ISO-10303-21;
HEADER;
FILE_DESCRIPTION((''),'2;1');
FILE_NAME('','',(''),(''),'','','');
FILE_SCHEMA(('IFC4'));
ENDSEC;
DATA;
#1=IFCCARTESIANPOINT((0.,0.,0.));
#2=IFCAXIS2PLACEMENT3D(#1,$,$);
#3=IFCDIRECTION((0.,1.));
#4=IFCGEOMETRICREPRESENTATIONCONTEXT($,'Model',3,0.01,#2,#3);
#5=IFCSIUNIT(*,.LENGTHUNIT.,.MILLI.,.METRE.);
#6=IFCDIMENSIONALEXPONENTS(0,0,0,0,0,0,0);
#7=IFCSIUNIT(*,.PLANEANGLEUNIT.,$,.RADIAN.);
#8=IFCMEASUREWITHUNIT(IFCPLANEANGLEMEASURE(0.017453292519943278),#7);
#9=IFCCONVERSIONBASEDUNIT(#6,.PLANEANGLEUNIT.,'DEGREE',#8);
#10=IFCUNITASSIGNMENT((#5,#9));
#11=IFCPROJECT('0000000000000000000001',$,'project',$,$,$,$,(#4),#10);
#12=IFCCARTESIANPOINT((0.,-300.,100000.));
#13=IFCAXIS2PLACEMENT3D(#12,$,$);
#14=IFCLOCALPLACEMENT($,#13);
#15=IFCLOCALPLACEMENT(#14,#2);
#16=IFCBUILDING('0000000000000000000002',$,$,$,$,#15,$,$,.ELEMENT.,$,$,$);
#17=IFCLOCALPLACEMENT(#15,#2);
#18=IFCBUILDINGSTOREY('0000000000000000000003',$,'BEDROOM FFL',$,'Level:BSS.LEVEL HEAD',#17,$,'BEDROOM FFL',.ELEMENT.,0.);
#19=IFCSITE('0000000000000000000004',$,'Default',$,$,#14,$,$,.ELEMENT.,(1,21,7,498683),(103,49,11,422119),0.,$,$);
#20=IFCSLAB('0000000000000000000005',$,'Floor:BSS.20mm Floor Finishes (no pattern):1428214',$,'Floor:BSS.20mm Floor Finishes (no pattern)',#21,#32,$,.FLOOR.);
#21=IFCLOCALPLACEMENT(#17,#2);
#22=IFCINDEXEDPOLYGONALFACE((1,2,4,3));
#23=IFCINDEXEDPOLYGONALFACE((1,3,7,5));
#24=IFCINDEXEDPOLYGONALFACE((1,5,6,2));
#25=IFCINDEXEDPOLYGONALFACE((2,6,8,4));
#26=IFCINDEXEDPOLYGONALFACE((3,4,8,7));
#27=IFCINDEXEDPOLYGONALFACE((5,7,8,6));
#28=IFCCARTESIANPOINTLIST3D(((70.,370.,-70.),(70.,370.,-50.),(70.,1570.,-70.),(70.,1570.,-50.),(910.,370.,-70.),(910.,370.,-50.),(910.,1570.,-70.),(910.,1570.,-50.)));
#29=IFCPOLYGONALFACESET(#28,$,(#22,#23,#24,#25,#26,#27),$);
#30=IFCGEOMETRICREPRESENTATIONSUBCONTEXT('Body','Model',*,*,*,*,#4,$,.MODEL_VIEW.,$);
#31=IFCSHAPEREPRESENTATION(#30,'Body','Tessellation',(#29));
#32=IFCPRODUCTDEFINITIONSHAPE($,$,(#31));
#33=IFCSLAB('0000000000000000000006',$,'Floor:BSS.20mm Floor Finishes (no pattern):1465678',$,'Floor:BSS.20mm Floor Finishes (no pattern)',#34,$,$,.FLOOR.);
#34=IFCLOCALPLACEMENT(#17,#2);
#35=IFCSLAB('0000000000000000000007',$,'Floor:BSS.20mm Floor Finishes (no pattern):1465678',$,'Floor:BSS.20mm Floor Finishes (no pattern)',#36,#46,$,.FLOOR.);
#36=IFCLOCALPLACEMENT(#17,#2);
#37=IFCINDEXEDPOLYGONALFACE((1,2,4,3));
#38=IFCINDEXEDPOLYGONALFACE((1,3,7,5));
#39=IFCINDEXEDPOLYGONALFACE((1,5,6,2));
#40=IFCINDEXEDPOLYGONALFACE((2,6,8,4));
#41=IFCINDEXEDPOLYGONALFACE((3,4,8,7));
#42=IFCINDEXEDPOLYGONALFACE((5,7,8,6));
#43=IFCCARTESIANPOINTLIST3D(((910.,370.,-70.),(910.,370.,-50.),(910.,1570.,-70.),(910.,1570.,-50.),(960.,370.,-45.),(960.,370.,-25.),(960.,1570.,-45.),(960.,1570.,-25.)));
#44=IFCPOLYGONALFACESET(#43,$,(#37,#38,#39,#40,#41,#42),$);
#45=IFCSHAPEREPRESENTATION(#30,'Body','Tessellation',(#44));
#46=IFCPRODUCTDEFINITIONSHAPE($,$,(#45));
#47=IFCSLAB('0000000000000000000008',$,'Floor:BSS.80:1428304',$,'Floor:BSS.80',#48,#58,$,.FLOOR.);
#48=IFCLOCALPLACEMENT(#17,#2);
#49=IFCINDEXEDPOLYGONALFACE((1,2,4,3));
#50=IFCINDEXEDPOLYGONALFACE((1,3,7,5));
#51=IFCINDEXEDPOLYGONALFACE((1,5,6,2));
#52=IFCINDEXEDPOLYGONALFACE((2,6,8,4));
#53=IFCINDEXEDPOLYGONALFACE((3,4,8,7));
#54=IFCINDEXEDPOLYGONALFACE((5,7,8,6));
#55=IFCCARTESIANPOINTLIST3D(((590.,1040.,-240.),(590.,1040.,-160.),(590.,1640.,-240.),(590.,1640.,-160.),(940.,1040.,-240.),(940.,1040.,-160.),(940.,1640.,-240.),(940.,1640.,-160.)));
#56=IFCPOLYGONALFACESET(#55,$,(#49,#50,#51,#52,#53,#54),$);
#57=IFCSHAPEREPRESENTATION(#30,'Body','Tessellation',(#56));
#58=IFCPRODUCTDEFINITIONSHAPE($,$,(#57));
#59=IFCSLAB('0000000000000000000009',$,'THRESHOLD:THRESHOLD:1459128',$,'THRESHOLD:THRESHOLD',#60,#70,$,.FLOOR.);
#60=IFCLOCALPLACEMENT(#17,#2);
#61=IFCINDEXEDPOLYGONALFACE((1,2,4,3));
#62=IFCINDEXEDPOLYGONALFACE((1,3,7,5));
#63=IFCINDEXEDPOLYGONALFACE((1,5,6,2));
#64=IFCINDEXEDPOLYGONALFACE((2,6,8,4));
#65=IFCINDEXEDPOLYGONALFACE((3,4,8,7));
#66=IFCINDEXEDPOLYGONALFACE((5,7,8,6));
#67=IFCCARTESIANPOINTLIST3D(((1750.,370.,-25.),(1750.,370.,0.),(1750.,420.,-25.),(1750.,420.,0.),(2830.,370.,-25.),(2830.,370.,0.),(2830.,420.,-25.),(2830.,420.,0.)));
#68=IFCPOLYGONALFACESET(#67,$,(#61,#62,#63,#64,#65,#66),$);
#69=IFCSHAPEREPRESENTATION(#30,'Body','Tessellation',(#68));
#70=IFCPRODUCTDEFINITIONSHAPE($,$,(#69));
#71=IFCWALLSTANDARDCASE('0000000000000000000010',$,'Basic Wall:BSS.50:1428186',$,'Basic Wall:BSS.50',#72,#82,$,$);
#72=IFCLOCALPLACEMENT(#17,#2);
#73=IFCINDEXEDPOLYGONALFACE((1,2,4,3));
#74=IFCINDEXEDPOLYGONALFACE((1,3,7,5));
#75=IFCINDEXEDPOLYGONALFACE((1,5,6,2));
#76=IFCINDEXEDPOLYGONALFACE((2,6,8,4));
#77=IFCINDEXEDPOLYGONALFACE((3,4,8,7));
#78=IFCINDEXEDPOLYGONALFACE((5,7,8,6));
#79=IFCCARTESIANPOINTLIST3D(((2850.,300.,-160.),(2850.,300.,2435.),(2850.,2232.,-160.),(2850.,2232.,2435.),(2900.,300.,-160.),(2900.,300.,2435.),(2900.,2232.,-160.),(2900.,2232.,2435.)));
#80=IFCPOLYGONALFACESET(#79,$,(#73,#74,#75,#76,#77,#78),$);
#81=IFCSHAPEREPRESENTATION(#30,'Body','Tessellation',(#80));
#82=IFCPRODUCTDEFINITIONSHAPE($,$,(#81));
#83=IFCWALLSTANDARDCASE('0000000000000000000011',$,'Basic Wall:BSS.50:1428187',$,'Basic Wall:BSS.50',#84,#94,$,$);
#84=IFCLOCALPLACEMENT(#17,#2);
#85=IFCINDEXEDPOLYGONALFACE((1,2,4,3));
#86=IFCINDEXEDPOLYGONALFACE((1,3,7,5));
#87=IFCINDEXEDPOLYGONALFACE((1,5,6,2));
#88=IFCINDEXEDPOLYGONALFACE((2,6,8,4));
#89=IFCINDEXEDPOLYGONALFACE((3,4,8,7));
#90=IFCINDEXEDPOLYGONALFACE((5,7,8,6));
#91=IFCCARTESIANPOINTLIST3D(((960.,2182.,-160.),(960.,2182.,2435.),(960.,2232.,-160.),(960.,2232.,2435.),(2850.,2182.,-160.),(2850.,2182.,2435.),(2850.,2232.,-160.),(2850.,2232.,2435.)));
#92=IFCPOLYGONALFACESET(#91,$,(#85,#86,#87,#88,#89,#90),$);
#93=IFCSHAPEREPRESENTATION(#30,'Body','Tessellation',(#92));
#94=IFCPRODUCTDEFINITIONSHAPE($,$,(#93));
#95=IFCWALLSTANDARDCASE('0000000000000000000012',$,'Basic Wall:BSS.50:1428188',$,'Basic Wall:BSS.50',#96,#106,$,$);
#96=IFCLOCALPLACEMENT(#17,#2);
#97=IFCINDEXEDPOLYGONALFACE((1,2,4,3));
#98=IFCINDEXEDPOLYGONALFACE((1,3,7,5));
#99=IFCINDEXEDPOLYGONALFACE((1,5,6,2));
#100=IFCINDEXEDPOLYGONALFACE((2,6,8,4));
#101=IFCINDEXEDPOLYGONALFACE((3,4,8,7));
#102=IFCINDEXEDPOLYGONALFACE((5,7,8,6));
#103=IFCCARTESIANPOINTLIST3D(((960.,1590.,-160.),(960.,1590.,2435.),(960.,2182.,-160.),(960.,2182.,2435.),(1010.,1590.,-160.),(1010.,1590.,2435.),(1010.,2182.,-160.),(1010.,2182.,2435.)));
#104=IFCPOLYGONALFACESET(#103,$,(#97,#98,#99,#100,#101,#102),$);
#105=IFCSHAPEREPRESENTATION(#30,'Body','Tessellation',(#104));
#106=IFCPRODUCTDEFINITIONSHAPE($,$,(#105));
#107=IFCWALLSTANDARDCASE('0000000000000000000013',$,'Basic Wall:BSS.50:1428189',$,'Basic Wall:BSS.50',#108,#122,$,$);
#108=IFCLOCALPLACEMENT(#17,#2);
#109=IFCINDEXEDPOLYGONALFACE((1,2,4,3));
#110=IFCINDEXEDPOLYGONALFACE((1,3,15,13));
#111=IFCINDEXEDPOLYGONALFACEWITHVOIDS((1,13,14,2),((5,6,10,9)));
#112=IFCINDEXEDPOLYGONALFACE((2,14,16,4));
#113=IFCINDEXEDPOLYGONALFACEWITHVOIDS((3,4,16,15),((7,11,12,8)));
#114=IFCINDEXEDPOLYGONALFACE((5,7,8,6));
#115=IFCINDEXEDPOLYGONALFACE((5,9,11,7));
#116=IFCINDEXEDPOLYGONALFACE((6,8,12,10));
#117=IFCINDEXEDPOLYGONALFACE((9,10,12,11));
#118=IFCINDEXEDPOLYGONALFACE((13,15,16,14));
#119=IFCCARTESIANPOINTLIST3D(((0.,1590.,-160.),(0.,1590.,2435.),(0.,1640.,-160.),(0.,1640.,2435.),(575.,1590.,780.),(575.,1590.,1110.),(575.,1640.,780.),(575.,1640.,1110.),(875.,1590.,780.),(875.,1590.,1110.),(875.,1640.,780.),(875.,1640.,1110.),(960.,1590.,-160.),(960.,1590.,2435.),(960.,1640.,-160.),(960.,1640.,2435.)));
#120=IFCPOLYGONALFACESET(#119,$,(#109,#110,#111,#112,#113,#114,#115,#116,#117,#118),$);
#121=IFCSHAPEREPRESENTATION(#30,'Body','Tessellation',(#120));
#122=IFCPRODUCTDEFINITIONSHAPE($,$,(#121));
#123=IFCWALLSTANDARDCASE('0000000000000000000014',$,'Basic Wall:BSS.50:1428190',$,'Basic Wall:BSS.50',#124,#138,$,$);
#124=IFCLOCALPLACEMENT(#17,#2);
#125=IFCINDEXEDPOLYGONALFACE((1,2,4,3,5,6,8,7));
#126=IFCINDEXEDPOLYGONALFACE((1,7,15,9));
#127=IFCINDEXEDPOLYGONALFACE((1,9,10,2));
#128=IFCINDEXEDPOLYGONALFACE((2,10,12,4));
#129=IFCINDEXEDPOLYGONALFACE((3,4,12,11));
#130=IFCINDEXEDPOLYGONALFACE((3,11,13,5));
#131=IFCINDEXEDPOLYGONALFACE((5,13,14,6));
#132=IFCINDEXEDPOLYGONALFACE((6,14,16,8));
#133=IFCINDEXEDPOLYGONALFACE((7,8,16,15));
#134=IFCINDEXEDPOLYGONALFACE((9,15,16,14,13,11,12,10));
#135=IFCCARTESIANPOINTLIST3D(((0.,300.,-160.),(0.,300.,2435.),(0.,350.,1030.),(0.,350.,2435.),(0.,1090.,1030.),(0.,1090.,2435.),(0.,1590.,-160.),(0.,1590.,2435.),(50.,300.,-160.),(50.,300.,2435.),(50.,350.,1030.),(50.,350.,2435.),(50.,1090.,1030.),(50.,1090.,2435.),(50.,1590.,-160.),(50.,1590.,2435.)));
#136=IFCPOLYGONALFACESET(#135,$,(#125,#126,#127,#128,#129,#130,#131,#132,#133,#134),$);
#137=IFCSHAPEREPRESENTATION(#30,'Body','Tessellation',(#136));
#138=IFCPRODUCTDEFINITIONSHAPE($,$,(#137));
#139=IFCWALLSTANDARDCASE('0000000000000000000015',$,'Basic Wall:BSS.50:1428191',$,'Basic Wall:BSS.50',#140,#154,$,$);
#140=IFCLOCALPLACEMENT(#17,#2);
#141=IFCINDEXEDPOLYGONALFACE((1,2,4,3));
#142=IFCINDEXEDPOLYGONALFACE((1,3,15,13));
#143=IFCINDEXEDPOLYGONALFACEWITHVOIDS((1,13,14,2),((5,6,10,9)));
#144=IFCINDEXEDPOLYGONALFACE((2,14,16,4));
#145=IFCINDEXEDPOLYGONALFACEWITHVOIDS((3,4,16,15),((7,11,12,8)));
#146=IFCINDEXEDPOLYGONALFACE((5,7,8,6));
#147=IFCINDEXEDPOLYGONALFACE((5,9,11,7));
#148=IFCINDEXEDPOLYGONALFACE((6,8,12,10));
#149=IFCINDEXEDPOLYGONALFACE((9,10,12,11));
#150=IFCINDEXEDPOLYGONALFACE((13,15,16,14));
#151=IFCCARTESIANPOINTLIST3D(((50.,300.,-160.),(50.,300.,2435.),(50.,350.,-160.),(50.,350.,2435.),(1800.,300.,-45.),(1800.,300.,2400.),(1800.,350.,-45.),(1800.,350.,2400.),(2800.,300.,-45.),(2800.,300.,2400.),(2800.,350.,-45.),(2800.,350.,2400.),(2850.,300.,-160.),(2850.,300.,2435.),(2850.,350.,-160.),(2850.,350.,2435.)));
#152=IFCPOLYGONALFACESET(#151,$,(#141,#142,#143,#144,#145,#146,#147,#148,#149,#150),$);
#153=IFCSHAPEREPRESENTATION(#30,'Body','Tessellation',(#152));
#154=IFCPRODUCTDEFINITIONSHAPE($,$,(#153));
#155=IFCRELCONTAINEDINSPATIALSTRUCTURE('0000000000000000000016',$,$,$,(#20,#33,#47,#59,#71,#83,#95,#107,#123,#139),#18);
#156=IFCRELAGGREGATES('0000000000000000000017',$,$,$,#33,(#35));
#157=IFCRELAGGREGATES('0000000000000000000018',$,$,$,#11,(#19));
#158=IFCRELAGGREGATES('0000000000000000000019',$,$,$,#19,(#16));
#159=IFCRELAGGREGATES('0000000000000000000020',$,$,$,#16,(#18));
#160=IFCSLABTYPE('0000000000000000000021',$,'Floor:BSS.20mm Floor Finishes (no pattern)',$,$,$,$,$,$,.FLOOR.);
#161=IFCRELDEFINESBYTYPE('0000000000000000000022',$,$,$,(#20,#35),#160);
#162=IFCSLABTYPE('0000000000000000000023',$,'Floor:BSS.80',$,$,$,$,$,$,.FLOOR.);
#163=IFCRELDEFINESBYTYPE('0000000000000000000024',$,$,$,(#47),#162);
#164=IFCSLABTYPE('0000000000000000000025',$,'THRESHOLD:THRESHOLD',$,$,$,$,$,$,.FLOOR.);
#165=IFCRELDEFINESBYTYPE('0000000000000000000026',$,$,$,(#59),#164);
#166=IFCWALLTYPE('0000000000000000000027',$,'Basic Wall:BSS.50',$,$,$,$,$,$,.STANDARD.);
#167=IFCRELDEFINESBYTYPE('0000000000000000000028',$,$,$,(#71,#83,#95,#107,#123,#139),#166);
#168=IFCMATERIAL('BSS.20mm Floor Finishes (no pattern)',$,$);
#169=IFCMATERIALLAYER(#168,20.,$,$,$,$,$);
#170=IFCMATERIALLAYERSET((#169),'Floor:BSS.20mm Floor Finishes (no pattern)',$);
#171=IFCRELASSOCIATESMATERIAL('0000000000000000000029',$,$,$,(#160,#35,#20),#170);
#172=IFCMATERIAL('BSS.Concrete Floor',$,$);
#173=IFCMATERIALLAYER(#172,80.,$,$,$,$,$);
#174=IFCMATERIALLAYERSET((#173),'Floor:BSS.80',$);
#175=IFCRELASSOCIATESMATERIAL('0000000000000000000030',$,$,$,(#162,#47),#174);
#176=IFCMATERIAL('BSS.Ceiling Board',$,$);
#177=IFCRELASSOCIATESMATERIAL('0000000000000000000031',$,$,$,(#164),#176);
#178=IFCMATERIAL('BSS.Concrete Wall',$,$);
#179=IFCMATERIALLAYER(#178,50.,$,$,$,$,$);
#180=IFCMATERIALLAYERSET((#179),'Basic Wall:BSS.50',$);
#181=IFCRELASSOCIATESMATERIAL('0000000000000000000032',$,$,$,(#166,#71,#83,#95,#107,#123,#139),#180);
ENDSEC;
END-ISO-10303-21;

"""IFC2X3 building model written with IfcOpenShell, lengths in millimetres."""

from ifc_helpers import new_model, entity, si_unit, converted_unit, direction, frame, frame_2d, origin, place, context, subcontext, project, spatial, rectangle, extrude, material, layer, layer_set, layer_usage, type_object, element, aggregate, save


model = new_model("IFC2X3")

# Units and contexts
model_context = context("Model", 3, precision=0.01, world=origin(), true_north=direction((0.0, 1.0)))
body_context = subcontext(model_context, "Body", "Model", "MODEL_VIEW")
ifc_project = project(units=[si_unit("LENGTHUNIT", "METRE", prefix="MILLI"), converted_unit("PLANEANGLEUNIT", "DEGREE", entity("IfcPlaneAngleMeasure", 0.017453292519943278), si_unit("PLANEANGLEUNIT", "RADIAN"), dimensions=[0, 0, 0, 0, 0, 0, 0])], contexts=[model_context])

# Site, building, storey
site_placement = place(None, frame((0.0, -300.0, 100000.0)))
site = spatial("IfcSite", under=ifc_project, at=site_placement, Name="Default", CompositionType="ELEMENT", RefLatitude=(1, 21, 7, 498683), RefLongitude=(103, 49, 11, 422119), RefElevation=0.0)
building_placement = place(site_placement, origin())
building = spatial("IfcBuilding", under=site, at=building_placement, CompositionType="ELEMENT")
storey_placement = place(building_placement, origin())
storey = spatial("IfcBuildingStorey", under=building, at=storey_placement, Name="BEDROOM FFL", ObjectType="Level:BSS.LEVEL HEAD", LongName="BEDROOM FFL", CompositionType="ELEMENT", Elevation=0.0)

# Slabs
ifc_material_1 = material(Name="BSS.Concrete Floor")
ifc_material_2 = material(Name="BSS.20mm Floor Finishes (no pattern)")
ifc_layer_1 = layer(ifc_material_2, 20.0)
ifc_layer_set_1 = layer_set([ifc_layer_1], Name="Floor:BSS.20mm Floor Finishes (no pattern)")
slab_type_1 = type_object("IfcSlabType", Name="Floor:BSS.20mm Floor Finishes (no pattern)", PredefinedType="FLOOR", material=ifc_layer_set_1)
ifc_layer_usage_1 = layer_usage(ifc_layer_set_1, "AXIS3", "POSITIVE", 0.0)
slab_1_placement = place(storey_placement, origin())
element("IfcSlab", 1, at=slab_1_placement, inside=storey, type_object=slab_type_1, material=ifc_layer_usage_1, Name="Floor:BSS.20mm Floor Finishes (no pattern):1428214", ObjectType="Floor:BSS.20mm Floor Finishes (no pattern)", PredefinedType="FLOOR", context=body_context, shape_type="SweptSolid", body=[
    extrude(rectangle(XDim=1200.0, YDim=840.0, at=frame_2d((0.0, 0.0), x_axis=(1.0, 0.0))), frame((490.0, 970.0, -50.0), z_axis=(0.0, 0.0, -1.0), x_axis=(0.0, 1.0, 0.0)), (0.0, 0.0, 1.0), 20.0),
])
slab_2_placement = place(storey_placement, frame((910.0, 370.0, -70.0)))
slab_2 = element("IfcSlab", 2, at=slab_2_placement, inside=storey, Name="Floor:BSS.20mm Floor Finishes (no pattern):1465678", ObjectType="Floor:BSS.20mm Floor Finishes (no pattern)", PredefinedType="FLOOR")
slab_3_placement = place(slab_2_placement, origin())
slab_3 = element("IfcSlab", 3, at=slab_3_placement, type_object=slab_type_1, material=ifc_layer_set_1, Name="Floor:BSS.20mm Floor Finishes (no pattern):1465678", ObjectType="Floor:BSS.20mm Floor Finishes (no pattern)", PredefinedType="FLOOR", context=body_context, shape_type="SweptSolid", body=[
    extrude(rectangle(XDim=1200.0, YDim=55.9, at=frame_2d((0.0, 0.0), x_axis=(0.0, -1.0))), frame((25.0, 600.0, 32.5), z_axis=(-0.447227, 0.0, 0.89442), x_axis=(0.89442, 0.0, 0.447227)), (-0.447227, 0.0, -0.89442), 20.0),
])
aggregate(slab_2, [slab_3])
ifc_layer_2 = layer(ifc_material_1, 80.0)
ifc_layer_set_2 = layer_set([ifc_layer_2], Name="Floor:BSS.80")
ifc_layer_usage_2 = layer_usage(ifc_layer_set_2, "AXIS3", "POSITIVE", 0.0)
slab_type_2 = type_object("IfcSlabType", Name="Floor:BSS.80", PredefinedType="FLOOR", material=ifc_layer_set_2)
slab_4_placement = place(storey_placement, origin())
element("IfcSlab", 4, at=slab_4_placement, inside=storey, type_object=slab_type_2, material=ifc_layer_usage_2, Name="Floor:BSS.80:1428304", ObjectType="Floor:BSS.80", PredefinedType="FLOOR", context=body_context, shape_type="SweptSolid", body=[
    extrude(rectangle(XDim=600.0, YDim=350.0, at=frame_2d((0.0, 0.0), x_axis=(1.0, 0.0))), frame((765.0, 1340.0, -160.0), z_axis=(0.0, 0.0, -1.0), x_axis=(0.0, 1.0, 0.0)), (0.0, 0.0, 1.0), 80.0),
])
ifc_material_3 = material(Name="BSS.Ceiling Board")
slab_type_3 = type_object("IfcSlabType", Name="THRESHOLD:THRESHOLD", PredefinedType="FLOOR", material=ifc_material_3)
slab_5_placement = place(storey_placement, origin())
element("IfcSlab", 5, at=slab_5_placement, inside=storey, type_object=slab_type_3, Name="THRESHOLD:THRESHOLD:1459128", ObjectType="THRESHOLD:THRESHOLD", PredefinedType="FLOOR", context=body_context, shape_type="SweptSolid", body=[
    extrude(rectangle(XDim=1080.0, YDim=50.0, at=frame_2d((0.0, 0.0), x_axis=(1.0, 0.0))), frame((2290.0, 395.0, -25.0)), (0.0, 0.0, 1.0), 25.0),
])

# Walls
ifc_material_4 = material(Name="BSS.Concrete Wall")
ifc_layer_3 = layer(ifc_material_4, 50.0)
ifc_layer_set_3 = layer_set([ifc_layer_3], Name="Basic Wall:BSS.50")
ifc_layer_usage_3 = layer_usage(ifc_layer_set_3, "AXIS2", "POSITIVE", -25.0)
wall_type_1 = type_object("IfcWallType", Name="Basic Wall:BSS.50", PredefinedType="STANDARD", material=ifc_layer_set_3)
wall_1_placement = place(storey_placement, frame((2875.0, 300.0, -160.0), z_axis=(0.0, 0.0, 1.0), x_axis=(0.0, 1.0, 0.0)))
element("IfcWallStandardCase", 6, at=wall_1_placement, inside=storey, type_object=wall_type_1, material=ifc_layer_usage_3, Name="Basic Wall:BSS.50:1428186", ObjectType="Basic Wall:BSS.50", context=body_context, shape_type="SweptSolid", body=[
    extrude(rectangle(XDim=1932.0, YDim=50.0, at=frame_2d((966.0, 0.0), x_axis=(-1.0, 0.0))), origin(), (0.0, 0.0, 1.0), 2595.0),
])
ifc_layer_usage_4 = layer_usage(ifc_layer_set_3, "AXIS2", "NEGATIVE", 25.0)
wall_2_placement = place(storey_placement, frame((2850.0, 2207.0, -160.0), z_axis=(0.0, 0.0, 1.0), x_axis=(-1.0, 0.0, 0.0)))
element("IfcWallStandardCase", 7, at=wall_2_placement, inside=storey, type_object=wall_type_1, material=ifc_layer_usage_4, Name="Basic Wall:BSS.50:1428187", ObjectType="Basic Wall:BSS.50", context=body_context, shape_type="SweptSolid", body=[
    extrude(rectangle(XDim=1890.0, YDim=50.0, at=frame_2d((945.0, 0.0), x_axis=(-1.0, 0.0))), origin(), (0.0, 0.0, 1.0), 2595.0),
])
ifc_layer_usage_5 = layer_usage(ifc_layer_set_3, "AXIS2", "NEGATIVE", 25.0)
wall_3_placement = place(storey_placement, frame((985.0, 2182.0, -160.0), z_axis=(0.0, 0.0, 1.0), x_axis=(0.0, -1.0, 0.0)))
element("IfcWallStandardCase", 8, at=wall_3_placement, inside=storey, type_object=wall_type_1, material=ifc_layer_usage_5, Name="Basic Wall:BSS.50:1428188", ObjectType="Basic Wall:BSS.50", context=body_context, shape_type="SweptSolid", body=[
    extrude(rectangle(XDim=592.0, YDim=50.0, at=frame_2d((296.0, 0.0), x_axis=(-1.0, 0.0))), origin(), (0.0, 0.0, 1.0), 2595.0),
])

# Walls, openings
ifc_layer_usage_6 = layer_usage(ifc_layer_set_3, "AXIS2", "NEGATIVE", 25.0)
wall_4_placement = place(storey_placement, frame((960.0, 1615.0, -160.0), z_axis=(0.0, 0.0, 1.0), x_axis=(-1.0, 0.0, 0.0)))
wall_4 = element("IfcWallStandardCase", 9, at=wall_4_placement, inside=storey, type_object=wall_type_1, material=ifc_layer_usage_6, Name="Basic Wall:BSS.50:1428189", ObjectType="Basic Wall:BSS.50", context=body_context, shape_type="SweptSolid", body=[
    extrude(rectangle(XDim=960.0, YDim=50.0, at=frame_2d((480.0, 0.0), x_axis=(-1.0, 0.0))), origin(), (0.0, 0.0, 1.0), 2595.0),
])
opening_1_placement = place(wall_4_placement, origin())
element("IfcOpeningElement", 10, at=opening_1_placement, cuts=wall_4, ObjectType="Opening", context=body_context, shape_type="SweptSolid", body=[
    extrude(rectangle(XDim=330.0, YDim=300.0, at=frame_2d((0.0, 0.0), x_axis=(0.0, 1.0))), frame((235.0, 25.0, 1105.0), z_axis=(0.0, -1.0, 0.0), x_axis=(-1.0, 0.0, 0.0)), (0.0, 0.0, 1.0), 50.0),
])
ifc_layer_usage_7 = layer_usage(ifc_layer_set_3, "AXIS2", "NEGATIVE", 25.0)
wall_5_placement = place(storey_placement, frame((25.0, 1590.0, -160.0), z_axis=(0.0, 0.0, 1.0), x_axis=(0.0, -1.0, 0.0)))
wall_5 = element("IfcWallStandardCase", 11, at=wall_5_placement, inside=storey, type_object=wall_type_1, material=ifc_layer_usage_7, Name="Basic Wall:BSS.50:1428190", ObjectType="Basic Wall:BSS.50", context=body_context, shape_type="SweptSolid", body=[
    extrude(rectangle(XDim=1290.0, YDim=50.0, at=frame_2d((645.0, 0.0), x_axis=(-1.0, 0.0))), origin(), (0.0, 0.0, 1.0), 2595.0),
])
opening_2_placement = place(wall_5_placement, frame((1590.0, -25.0, 160.0), z_axis=(0.0, 0.0, 1.0), x_axis=(0.0, 1.0, 0.0)))
element("IfcOpeningElement", 12, at=opening_2_placement, cuts=wall_5, ObjectType="Opening", context=body_context, shape_type="SweptSolid", body=[
    extrude(rectangle(XDim=1405.0, YDim=740.0, at=frame_2d((0.0, 0.0), x_axis=(1.0, 0.0))), frame((-1474.0, 720.0, 1732.5), z_axis=(1.0, 0.0, 0.0), x_axis=(0.0, 0.0, -1.0)), (0.0, 0.0, 1.0), 3048.0),
])
ifc_layer_usage_8 = layer_usage(ifc_layer_set_3, "AXIS2", "POSITIVE", -25.0)
wall_6_placement = place(storey_placement, frame((50.0, 325.0, -160.0)))
wall_6 = element("IfcWallStandardCase", 13, at=wall_6_placement, inside=storey, type_object=wall_type_1, material=ifc_layer_usage_8, Name="Basic Wall:BSS.50:1428191", ObjectType="Basic Wall:BSS.50", context=body_context, shape_type="SweptSolid", body=[
    extrude(rectangle(XDim=2800.0, YDim=50.0, at=frame_2d((1400.0, 0.0), x_axis=(-1.0, 0.0))), origin(), (0.0, 0.0, 1.0), 2595.0),
])
opening_3_placement = place(wall_6_placement, frame((-50.0, -325.0, 160.0)))
element("IfcOpeningElement", 14, at=opening_3_placement, cuts=wall_6, ObjectType="Opening", context=body_context, shape_type="SweptSolid", body=[
    extrude(rectangle(XDim=2445.0, YDim=1000.0, at=frame_2d((0.0, 0.0), x_axis=(1.0, 0.0))), frame((2300.0, -1174.0, 1177.5), z_axis=(0.0, 1.0, 0.0), x_axis=(0.0, 0.0, -1.0)), (0.0, 0.0, 1.0), 3048.0),
])

save(model, "model.ifc")
